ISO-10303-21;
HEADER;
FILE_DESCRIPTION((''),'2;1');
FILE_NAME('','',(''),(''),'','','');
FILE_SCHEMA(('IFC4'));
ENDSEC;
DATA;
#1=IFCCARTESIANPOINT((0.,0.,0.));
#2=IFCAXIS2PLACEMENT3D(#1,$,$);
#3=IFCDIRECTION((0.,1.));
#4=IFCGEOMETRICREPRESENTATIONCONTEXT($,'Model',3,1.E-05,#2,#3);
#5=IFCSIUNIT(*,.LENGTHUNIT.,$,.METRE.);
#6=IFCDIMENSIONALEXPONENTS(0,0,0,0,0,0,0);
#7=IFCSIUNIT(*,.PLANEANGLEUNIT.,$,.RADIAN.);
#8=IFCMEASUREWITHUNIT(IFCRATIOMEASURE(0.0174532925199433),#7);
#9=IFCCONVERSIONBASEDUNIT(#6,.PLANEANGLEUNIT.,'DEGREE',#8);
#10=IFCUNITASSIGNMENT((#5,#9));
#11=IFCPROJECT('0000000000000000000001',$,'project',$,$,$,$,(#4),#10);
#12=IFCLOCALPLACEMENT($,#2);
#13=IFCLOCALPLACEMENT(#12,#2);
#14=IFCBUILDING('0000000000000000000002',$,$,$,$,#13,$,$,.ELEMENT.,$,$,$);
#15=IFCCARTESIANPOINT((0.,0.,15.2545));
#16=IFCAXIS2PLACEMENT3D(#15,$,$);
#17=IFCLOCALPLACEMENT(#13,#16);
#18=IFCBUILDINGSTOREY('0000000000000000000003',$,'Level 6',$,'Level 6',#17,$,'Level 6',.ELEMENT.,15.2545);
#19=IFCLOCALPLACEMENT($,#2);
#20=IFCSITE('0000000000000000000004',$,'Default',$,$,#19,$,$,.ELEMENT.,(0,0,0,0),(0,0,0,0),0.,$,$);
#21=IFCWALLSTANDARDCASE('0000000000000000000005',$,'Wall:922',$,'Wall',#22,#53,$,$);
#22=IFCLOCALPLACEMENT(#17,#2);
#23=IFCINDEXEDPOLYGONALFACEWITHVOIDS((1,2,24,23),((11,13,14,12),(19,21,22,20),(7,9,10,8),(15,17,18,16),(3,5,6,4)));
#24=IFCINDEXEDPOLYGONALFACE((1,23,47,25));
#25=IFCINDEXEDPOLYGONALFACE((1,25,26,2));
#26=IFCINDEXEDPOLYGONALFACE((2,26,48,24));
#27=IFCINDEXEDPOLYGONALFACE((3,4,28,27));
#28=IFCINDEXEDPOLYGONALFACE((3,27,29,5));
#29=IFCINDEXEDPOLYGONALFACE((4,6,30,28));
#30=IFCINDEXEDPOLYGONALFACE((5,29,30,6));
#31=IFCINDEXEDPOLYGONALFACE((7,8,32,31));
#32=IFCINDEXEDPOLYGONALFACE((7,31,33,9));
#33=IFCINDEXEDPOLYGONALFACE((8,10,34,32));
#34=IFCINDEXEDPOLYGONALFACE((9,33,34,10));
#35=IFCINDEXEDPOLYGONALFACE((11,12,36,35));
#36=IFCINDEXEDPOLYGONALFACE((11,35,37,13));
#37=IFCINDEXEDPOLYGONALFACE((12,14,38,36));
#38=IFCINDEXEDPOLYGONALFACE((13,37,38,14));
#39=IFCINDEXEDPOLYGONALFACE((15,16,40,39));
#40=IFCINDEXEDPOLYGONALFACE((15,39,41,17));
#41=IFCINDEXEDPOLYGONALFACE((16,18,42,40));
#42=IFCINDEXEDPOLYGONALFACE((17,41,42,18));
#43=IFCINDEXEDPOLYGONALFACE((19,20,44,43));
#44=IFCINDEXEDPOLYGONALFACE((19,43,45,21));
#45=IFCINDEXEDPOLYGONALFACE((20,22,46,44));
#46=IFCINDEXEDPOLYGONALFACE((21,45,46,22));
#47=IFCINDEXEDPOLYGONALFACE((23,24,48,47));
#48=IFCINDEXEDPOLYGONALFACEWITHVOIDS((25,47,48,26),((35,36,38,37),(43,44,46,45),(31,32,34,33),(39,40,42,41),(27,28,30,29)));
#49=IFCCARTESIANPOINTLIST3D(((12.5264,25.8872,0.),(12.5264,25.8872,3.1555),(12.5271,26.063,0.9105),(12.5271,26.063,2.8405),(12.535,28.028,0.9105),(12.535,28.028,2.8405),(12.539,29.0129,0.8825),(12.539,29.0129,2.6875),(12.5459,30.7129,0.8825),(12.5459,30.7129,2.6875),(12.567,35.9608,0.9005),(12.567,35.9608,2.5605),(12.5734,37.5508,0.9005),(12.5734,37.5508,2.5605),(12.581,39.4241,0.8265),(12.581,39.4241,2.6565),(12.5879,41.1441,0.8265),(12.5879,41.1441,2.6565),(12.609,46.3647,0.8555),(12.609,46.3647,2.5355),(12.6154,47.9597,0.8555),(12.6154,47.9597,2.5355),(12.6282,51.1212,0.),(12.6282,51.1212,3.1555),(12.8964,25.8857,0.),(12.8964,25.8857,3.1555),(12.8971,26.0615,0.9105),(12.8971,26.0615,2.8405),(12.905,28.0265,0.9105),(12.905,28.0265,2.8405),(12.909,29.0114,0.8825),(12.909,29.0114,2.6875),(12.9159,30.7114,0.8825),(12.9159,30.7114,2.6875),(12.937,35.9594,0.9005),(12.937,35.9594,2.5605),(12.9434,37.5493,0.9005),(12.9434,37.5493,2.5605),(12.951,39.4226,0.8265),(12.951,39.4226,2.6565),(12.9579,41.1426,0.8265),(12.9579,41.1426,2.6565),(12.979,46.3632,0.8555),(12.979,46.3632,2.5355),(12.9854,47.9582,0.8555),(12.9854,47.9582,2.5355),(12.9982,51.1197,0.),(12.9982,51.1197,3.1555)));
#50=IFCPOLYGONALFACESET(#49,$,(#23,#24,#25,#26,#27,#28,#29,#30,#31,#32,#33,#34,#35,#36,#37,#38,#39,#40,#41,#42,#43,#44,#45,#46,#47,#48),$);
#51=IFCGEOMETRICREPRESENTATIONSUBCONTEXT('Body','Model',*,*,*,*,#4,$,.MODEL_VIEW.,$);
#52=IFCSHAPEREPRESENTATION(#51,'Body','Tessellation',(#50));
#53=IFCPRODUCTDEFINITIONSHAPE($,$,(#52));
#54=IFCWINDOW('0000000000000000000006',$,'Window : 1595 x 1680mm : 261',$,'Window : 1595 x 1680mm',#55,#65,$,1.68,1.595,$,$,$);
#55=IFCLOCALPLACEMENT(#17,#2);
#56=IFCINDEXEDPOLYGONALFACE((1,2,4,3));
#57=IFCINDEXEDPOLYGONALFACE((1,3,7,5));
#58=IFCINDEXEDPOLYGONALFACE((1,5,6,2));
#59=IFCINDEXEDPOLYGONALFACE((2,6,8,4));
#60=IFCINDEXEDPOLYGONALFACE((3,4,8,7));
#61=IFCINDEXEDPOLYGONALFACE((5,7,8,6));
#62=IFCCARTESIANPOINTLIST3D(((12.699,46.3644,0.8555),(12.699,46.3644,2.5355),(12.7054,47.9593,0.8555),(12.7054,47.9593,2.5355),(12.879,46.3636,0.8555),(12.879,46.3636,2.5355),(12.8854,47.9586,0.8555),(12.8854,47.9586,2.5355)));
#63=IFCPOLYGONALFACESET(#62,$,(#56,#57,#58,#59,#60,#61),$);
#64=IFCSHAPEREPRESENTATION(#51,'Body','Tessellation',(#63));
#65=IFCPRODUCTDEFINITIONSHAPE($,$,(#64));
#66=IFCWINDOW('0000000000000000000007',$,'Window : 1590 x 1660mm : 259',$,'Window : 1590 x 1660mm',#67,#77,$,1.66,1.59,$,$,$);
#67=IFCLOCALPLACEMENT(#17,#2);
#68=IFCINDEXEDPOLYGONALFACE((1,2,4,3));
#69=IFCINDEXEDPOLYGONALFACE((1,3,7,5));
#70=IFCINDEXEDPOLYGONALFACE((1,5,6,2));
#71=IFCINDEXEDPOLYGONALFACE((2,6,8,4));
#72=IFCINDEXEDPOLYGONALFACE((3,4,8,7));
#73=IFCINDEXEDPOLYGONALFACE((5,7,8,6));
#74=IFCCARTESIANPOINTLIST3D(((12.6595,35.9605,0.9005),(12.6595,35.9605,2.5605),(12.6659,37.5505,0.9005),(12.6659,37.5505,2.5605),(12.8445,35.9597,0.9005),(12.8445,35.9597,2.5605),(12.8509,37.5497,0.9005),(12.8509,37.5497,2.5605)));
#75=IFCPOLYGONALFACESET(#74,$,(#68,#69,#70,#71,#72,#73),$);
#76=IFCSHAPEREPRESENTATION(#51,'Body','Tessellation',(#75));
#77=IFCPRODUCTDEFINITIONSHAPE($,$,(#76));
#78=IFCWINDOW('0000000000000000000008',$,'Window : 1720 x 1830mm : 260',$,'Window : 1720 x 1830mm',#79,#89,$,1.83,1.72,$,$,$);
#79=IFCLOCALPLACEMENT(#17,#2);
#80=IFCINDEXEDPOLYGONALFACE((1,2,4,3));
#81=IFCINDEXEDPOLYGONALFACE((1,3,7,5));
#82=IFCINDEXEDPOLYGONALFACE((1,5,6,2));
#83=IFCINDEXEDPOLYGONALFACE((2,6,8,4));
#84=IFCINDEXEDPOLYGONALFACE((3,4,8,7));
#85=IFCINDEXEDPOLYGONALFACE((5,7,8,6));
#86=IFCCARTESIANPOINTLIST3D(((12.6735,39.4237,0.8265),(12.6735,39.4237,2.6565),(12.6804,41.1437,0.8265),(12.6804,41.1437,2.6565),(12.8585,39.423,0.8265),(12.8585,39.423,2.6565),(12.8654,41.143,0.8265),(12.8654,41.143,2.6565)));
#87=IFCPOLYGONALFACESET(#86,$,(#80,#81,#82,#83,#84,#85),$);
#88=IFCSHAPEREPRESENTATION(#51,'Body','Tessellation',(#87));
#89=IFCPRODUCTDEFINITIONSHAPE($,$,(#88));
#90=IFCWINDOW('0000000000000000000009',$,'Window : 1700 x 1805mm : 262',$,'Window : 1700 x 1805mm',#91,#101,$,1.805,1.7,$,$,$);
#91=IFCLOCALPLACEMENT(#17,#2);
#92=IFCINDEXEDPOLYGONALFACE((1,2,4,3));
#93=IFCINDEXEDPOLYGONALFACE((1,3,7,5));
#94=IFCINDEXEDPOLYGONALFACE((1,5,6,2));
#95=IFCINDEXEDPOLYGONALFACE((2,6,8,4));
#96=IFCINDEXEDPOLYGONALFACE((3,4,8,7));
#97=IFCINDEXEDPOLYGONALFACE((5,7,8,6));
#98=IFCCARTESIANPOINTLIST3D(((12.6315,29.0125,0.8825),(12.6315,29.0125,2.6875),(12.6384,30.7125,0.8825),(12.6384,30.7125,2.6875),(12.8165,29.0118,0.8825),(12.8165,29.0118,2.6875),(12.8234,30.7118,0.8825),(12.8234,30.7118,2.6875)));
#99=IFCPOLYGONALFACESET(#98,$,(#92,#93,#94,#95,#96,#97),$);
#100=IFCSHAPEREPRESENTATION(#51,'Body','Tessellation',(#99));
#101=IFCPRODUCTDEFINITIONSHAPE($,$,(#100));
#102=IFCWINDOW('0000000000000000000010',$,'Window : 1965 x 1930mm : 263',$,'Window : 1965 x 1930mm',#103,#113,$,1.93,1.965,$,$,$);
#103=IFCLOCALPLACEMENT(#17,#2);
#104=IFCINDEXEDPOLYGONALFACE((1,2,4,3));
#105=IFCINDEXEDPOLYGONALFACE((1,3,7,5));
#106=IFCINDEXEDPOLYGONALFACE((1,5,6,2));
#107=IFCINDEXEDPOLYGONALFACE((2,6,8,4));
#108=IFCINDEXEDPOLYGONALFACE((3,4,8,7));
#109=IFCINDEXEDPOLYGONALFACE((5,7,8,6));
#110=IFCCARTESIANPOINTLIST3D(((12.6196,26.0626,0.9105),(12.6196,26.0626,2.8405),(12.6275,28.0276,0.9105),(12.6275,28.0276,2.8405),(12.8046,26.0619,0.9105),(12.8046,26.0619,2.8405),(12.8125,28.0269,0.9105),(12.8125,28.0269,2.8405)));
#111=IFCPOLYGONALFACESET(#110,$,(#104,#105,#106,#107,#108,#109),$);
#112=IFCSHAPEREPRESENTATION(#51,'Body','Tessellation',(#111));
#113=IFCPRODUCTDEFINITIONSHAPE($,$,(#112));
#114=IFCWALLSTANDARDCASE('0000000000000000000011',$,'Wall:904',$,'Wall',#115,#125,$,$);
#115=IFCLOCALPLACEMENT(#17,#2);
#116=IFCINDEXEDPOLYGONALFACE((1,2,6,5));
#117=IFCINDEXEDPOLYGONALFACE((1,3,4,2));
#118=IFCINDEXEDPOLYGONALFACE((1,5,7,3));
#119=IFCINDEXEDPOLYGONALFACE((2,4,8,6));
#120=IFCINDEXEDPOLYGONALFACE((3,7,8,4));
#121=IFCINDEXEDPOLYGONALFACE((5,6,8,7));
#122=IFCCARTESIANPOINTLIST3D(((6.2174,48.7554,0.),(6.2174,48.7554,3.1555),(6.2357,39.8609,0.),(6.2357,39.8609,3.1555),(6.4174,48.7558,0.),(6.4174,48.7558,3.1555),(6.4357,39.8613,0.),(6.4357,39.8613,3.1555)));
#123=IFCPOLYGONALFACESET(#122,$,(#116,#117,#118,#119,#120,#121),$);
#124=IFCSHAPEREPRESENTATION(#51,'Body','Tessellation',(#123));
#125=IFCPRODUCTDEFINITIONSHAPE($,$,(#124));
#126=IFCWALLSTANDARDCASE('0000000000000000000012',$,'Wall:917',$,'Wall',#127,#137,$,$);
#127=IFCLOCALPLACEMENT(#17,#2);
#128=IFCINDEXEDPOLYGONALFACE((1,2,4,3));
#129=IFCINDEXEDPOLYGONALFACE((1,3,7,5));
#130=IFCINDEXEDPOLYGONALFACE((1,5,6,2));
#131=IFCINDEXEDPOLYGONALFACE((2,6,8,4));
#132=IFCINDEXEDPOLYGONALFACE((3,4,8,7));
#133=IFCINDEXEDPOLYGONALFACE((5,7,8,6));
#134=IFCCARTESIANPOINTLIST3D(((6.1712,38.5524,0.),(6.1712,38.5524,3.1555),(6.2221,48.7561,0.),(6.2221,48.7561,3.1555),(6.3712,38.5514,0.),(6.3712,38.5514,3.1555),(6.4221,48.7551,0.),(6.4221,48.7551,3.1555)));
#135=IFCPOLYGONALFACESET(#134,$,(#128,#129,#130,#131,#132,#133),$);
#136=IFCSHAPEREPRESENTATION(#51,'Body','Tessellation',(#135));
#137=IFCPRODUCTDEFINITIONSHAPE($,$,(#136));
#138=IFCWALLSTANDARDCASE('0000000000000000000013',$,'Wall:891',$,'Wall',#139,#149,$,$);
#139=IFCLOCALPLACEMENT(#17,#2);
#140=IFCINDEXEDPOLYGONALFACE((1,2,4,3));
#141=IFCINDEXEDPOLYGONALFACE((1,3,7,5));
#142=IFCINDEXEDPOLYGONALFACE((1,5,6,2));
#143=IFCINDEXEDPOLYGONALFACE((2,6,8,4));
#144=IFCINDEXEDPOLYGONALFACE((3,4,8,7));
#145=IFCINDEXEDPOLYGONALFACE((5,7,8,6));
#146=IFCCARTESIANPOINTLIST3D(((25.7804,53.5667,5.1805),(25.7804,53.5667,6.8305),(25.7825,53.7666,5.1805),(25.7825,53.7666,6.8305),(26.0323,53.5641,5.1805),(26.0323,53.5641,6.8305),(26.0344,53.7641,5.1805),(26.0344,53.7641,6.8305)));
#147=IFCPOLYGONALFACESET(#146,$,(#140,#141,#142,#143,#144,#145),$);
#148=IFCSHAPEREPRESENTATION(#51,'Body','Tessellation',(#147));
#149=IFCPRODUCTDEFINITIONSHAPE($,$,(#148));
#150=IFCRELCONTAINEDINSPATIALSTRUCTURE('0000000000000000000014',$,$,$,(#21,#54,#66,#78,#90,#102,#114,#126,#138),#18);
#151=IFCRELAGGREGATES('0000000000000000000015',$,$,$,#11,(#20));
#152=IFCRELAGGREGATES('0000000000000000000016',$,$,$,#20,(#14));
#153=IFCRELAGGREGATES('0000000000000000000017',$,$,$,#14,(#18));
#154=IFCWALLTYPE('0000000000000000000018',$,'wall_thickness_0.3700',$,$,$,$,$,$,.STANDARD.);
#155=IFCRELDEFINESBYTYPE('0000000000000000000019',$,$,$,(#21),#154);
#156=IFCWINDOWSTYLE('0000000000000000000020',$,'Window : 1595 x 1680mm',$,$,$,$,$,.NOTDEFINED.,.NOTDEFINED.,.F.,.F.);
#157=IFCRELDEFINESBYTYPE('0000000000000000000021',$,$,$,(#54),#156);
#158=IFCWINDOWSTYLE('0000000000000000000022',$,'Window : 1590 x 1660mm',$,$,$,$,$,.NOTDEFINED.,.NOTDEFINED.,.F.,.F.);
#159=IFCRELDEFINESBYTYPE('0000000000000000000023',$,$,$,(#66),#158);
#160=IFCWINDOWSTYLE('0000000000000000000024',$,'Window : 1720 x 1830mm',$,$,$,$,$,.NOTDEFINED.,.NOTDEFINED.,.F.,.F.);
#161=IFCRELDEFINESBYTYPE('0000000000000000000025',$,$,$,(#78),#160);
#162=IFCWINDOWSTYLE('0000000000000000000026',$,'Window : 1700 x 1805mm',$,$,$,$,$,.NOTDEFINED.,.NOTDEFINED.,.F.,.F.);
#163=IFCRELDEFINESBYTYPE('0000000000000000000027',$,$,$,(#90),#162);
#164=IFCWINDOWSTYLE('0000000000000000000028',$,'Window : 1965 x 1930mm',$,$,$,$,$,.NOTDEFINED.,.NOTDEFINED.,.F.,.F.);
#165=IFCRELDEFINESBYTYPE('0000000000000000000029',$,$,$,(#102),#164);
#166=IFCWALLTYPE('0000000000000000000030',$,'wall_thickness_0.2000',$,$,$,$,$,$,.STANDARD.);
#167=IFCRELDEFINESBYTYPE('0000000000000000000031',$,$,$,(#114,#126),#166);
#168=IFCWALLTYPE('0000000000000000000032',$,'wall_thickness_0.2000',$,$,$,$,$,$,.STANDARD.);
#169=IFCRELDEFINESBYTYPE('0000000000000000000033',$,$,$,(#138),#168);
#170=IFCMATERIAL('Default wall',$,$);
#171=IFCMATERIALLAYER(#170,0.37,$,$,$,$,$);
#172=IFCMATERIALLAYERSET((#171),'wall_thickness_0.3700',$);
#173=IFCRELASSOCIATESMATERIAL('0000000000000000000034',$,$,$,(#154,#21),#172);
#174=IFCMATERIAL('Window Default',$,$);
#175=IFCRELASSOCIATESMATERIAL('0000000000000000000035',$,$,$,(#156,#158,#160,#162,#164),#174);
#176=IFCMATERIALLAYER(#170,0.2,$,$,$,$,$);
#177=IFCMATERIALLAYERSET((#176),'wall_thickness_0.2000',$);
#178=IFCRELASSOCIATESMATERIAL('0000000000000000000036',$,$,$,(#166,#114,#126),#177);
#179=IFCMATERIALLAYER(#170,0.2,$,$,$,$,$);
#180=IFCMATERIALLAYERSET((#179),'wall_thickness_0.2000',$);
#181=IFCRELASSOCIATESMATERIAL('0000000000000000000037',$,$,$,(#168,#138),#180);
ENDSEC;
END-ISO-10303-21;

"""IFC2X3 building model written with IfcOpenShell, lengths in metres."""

from ifc_helpers import new_model, entity, si_unit, converted_unit, direction, frame, frame_2d, origin, origin_2d_with_axis, place, context, subcontext, project, spatial, polyline, rectangle, outline, extrude, source, transform, mapped, material, layer, layer_set, layer_usage, type_object, type_shapes, element, fill, save


model = new_model("IFC2X3")

# Units and contexts
model_context = context("Model", 3, precision=1e-05, world=origin(), true_north=direction((0.0, 1.0)))
body_context = subcontext(model_context, "Body", "Model", "MODEL_VIEW")
ifc_project = project(units=[si_unit("LENGTHUNIT", "METRE"), converted_unit("PLANEANGLEUNIT", "DEGREE", entity("IfcRatioMeasure", 0.0174532925199433), si_unit("PLANEANGLEUNIT", "RADIAN"), dimensions=[0, 0, 0, 0, 0, 0, 0])], contexts=[model_context])

# Site, building, storey
site_placement = place(None, origin())
site = spatial("IfcSite", under=ifc_project, at=site_placement, Name="Default", CompositionType="ELEMENT", RefLatitude=(0, 0, 0, 0), RefLongitude=(0, 0, 0, 0), RefElevation=0.0)
placement_1 = place(None, origin())
building_placement = place(placement_1, origin())
building = spatial("IfcBuilding", under=site, at=building_placement, CompositionType="ELEMENT")
storey_placement = place(building_placement, frame((0.0, 0.0, 15.2545)))
storey = spatial("IfcBuildingStorey", under=building, at=storey_placement, Name="Level 6", ObjectType="Level 6", LongName="Level 6", CompositionType="ELEMENT", Elevation=15.2545)

# Shared definitions
ifc_material_1 = material(Name="Default wall")
ifc_layer_1 = layer(ifc_material_1, 0.37)
ifc_layer_set_1 = layer_set([ifc_layer_1], Name="wall_thickness_0.3700")
ifc_layer_usage_1 = layer_usage(ifc_layer_set_1, "AXIS2", "POSITIVE", -0.185)
wall_type_1 = type_object("IfcWallType", Name="wall_thickness_0.3700", PredefinedType="STANDARD", material=ifc_layer_set_1)
ifc_material_2 = material(Name="Window Default")

# Wall, openings, windows
wall_1_placement = place(storey_placement, frame((12.8132, 51.1205, 0.0), z_axis=(0.0, 0.0, 1.0), x_axis=(-0.004033, -0.999992, 0.0)))
wall_1 = element("IfcWallStandardCase", 1, at=wall_1_placement, inside=storey, type_object=wall_type_1, material=ifc_layer_usage_1, Name="Wall:922", ObjectType="Wall", context=body_context, shape_type="SweptSolid", body=[
    extrude(outline(polyline([(25.2342, -0.185), (25.2342, 0.185), (0.0, 0.185), (0.0, -0.185), (25.2342, -0.185)])), origin(), (0.0, 0.0, 1.0), 3.1555),
])
opening_1_placement = place(wall_1_placement, frame((13.5705, -0.185, 0.9005)))
opening_1 = element("IfcOpeningElement", 2, at=opening_1_placement, cuts=wall_1, ObjectType="Opening", context=body_context, shape_type="SweptSolid", body=[
    extrude(rectangle(XDim=1.59, YDim=1.66, at=frame_2d((0.83, 0.795), x_axis=(0.0, 1.0))), frame((0.0, 0.0, 0.0), z_axis=(0.0, 1.0, 0.0), x_axis=(0.0, 0.0, 1.0)), (0.0, 0.0, 1.0), 0.37),
])
opening_2_placement = place(wall_1_placement, frame((9.9772, -0.185, 0.8265)))
opening_2 = element("IfcOpeningElement", 3, at=opening_2_placement, cuts=wall_1, ObjectType="Opening", context=body_context, shape_type="SweptSolid", body=[
    extrude(rectangle(XDim=1.72, YDim=1.83, at=frame_2d((0.915, 0.86), x_axis=(0.0, 1.0))), frame((0.0, 0.0, 0.0), z_axis=(0.0, 1.0, 0.0), x_axis=(0.0, 0.0, 1.0)), (0.0, 0.0, 1.0), 0.37),
])
opening_3_placement = place(wall_1_placement, frame((3.1615, -0.185, 0.8555)))
opening_3 = element("IfcOpeningElement", 4, at=opening_3_placement, cuts=wall_1, ObjectType="Opening", context=body_context, shape_type="SweptSolid", body=[
    extrude(rectangle(XDim=1.595, YDim=1.68, at=frame_2d((0.84, 0.7975), x_axis=(0.0, 1.0))), frame((0.0, 0.0, 0.0), z_axis=(0.0, 1.0, 0.0), x_axis=(0.0, 0.0, 1.0)), (0.0, 0.0, 1.0), 0.37),
])
opening_4_placement = place(wall_1_placement, frame((20.4085, -0.185, 0.8825)))
opening_4 = element("IfcOpeningElement", 5, at=opening_4_placement, cuts=wall_1, ObjectType="Opening", context=body_context, shape_type="SweptSolid", body=[
    extrude(rectangle(XDim=1.7, YDim=1.805, at=frame_2d((0.9025, 0.85), x_axis=(0.0, 1.0))), frame((0.0, 0.0, 0.0), z_axis=(0.0, 1.0, 0.0), x_axis=(0.0, 0.0, 1.0)), (0.0, 0.0, 1.0), 0.37),
])
opening_5_placement = place(wall_1_placement, frame((23.0934, -0.185, 0.9105)))
opening_5 = element("IfcOpeningElement", 6, at=opening_5_placement, cuts=wall_1, ObjectType="Opening", context=body_context, shape_type="SweptSolid", body=[
    extrude(rectangle(XDim=1.965, YDim=1.93, at=frame_2d((0.965, 0.9825), x_axis=(0.0, 1.0))), frame((0.0, 0.0, 0.0), z_axis=(0.0, 1.0, 0.0), x_axis=(0.0, 0.0, 1.0)), (0.0, 0.0, 1.0), 0.37),
])
window_style_1 = type_object("IfcWindowStyle", Name="Window : 1595 x 1680mm", ConstructionType="NOTDEFINED", OperationType="NOTDEFINED", ParameterTakesPrecedence=False, Sizeable=False, material=ifc_material_2)
shared_shape_1 = source(origin(), body_context, "Body", "SweptSolid", [
    extrude(rectangle(XDim=0.18, YDim=1.595, at=origin_2d_with_axis()), frame((0.7975, 0.18, 0.0), z_axis=(0.0, 0.0, 1.0), x_axis=(0.0, 1.0, 0.0)), (0.0, 0.0, 1.0), 1.68),
])
type_shapes(window_style_1, [shared_shape_1])
window_1_placement = place(opening_3_placement, origin())
window_1 = element("IfcWindow", 7, at=window_1_placement, inside=storey, type_object=window_style_1, Name="Window : 1595 x 1680mm : 261", ObjectType="Window : 1595 x 1680mm", OverallHeight=1.68, OverallWidth=1.595, context=body_context, shape_type="MappedRepresentation", body=[
    mapped(shared_shape_1, transform((0.0, 0.0, 0.0), scale=1.0)),
])
fill(opening_3, window_1)
window_style_2 = type_object("IfcWindowStyle", Name="Window : 1590 x 1660mm", ConstructionType="NOTDEFINED", OperationType="NOTDEFINED", ParameterTakesPrecedence=False, Sizeable=False, material=ifc_material_2)
shared_shape_2 = source(origin(), body_context, "Body", "SweptSolid", [
    extrude(rectangle(XDim=0.185, YDim=1.59, at=origin_2d_with_axis()), frame((0.795, 0.185, 0.0), z_axis=(0.0, 0.0, 1.0), x_axis=(0.0, 1.0, 0.0)), (0.0, 0.0, 1.0), 1.66),
])
type_shapes(window_style_2, [shared_shape_2])
window_2_placement = place(opening_1_placement, origin())
window_2 = element("IfcWindow", 8, at=window_2_placement, inside=storey, type_object=window_style_2, Name="Window : 1590 x 1660mm : 259", ObjectType="Window : 1590 x 1660mm", OverallHeight=1.66, OverallWidth=1.59, context=body_context, shape_type="MappedRepresentation", body=[
    mapped(shared_shape_2, transform((0.0, 0.0, 0.0), scale=1.0)),
])
fill(opening_1, window_2)
window_style_3 = type_object("IfcWindowStyle", Name="Window : 1720 x 1830mm", ConstructionType="NOTDEFINED", OperationType="NOTDEFINED", ParameterTakesPrecedence=False, Sizeable=False, material=ifc_material_2)
shared_shape_3 = source(origin(), body_context, "Body", "SweptSolid", [
    extrude(rectangle(XDim=0.185, YDim=1.72, at=origin_2d_with_axis()), frame((0.86, 0.185, 0.0), z_axis=(0.0, 0.0, 1.0), x_axis=(0.0, 1.0, 0.0)), (0.0, 0.0, 1.0), 1.83),
])
type_shapes(window_style_3, [shared_shape_3])
window_3_placement = place(opening_2_placement, origin())
window_3 = element("IfcWindow", 9, at=window_3_placement, inside=storey, type_object=window_style_3, Name="Window : 1720 x 1830mm : 260", ObjectType="Window : 1720 x 1830mm", OverallHeight=1.83, OverallWidth=1.72, context=body_context, shape_type="MappedRepresentation", body=[
    mapped(shared_shape_3, transform((0.0, 0.0, 0.0), scale=1.0)),
])
fill(opening_2, window_3)
window_style_4 = type_object("IfcWindowStyle", Name="Window : 1700 x 1805mm", ConstructionType="NOTDEFINED", OperationType="NOTDEFINED", ParameterTakesPrecedence=False, Sizeable=False, material=ifc_material_2)
shared_shape_4 = source(origin(), body_context, "Body", "SweptSolid", [
    extrude(rectangle(XDim=0.185, YDim=1.7, at=origin_2d_with_axis()), frame((0.85, 0.185, 0.0), z_axis=(0.0, 0.0, 1.0), x_axis=(0.0, 1.0, 0.0)), (0.0, 0.0, 1.0), 1.805),
])
type_shapes(window_style_4, [shared_shape_4])
window_4_placement = place(opening_4_placement, origin())
window_4 = element("IfcWindow", 10, at=window_4_placement, inside=storey, type_object=window_style_4, Name="Window : 1700 x 1805mm : 262", ObjectType="Window : 1700 x 1805mm", OverallHeight=1.805, OverallWidth=1.7, context=body_context, shape_type="MappedRepresentation", body=[
    mapped(shared_shape_4, transform((0.0, 0.0, 0.0), scale=1.0)),
])
fill(opening_4, window_4)
window_style_5 = type_object("IfcWindowStyle", Name="Window : 1965 x 1930mm", ConstructionType="NOTDEFINED", OperationType="NOTDEFINED", ParameterTakesPrecedence=False, Sizeable=False, material=ifc_material_2)
shared_shape_5 = source(origin(), body_context, "Body", "SweptSolid", [
    extrude(rectangle(XDim=0.185, YDim=1.965, at=origin_2d_with_axis()), frame((0.9825, 0.185, 0.0), z_axis=(0.0, 0.0, 1.0), x_axis=(0.0, 1.0, 0.0)), (0.0, 0.0, 1.0), 1.93),
])
type_shapes(window_style_5, [shared_shape_5])
window_5_placement = place(opening_5_placement, origin())
window_5 = element("IfcWindow", 11, at=window_5_placement, inside=storey, type_object=window_style_5, Name="Window : 1965 x 1930mm : 263", ObjectType="Window : 1965 x 1930mm", OverallHeight=1.93, OverallWidth=1.965, context=body_context, shape_type="MappedRepresentation", body=[
    mapped(shared_shape_5, transform((0.0, 0.0, 0.0), scale=1.0)),
])
fill(opening_5, window_5)

# Walls
ifc_layer_2 = layer(ifc_material_1, 0.2)
ifc_layer_set_2 = layer_set([ifc_layer_2], Name="wall_thickness_0.2000")
ifc_layer_usage_2 = layer_usage(ifc_layer_set_2, "AXIS2", "POSITIVE", -0.1)
wall_type_2 = type_object("IfcWallType", Name="wall_thickness_0.2000", PredefinedType="STANDARD", material=ifc_layer_set_2)
wall_2_placement = place(storey_placement, frame((6.3174, 48.7556, 0.0), z_axis=(0.0, 0.0, 1.0), x_axis=(0.002062, -0.999998, 0.0)))
element("IfcWallStandardCase", 12, at=wall_2_placement, inside=storey, type_object=wall_type_2, material=ifc_layer_usage_2, Name="Wall:904", ObjectType="Wall", context=body_context, shape_type="SweptSolid", body=[
    extrude(outline(polyline([(8.8945, -0.1), (8.8945, 0.1), (0.0, 0.1), (0.0, -0.1), (8.8945, -0.1)])), origin(), (0.0, 0.0, 1.0), 3.1555),
])
wall_3_placement = place(storey_placement, frame((6.3221, 48.7556, 0.0), z_axis=(0.0, 0.0, 1.0), x_axis=(-0.004992, -0.999988, 0.0)))
element("IfcWallStandardCase", 13, at=wall_3_placement, inside=storey, type_object=wall_type_2, material=ifc_layer_usage_2, Name="Wall:917", ObjectType="Wall", context=body_context, shape_type="SweptSolid", body=[
    extrude(outline(polyline([(10.2037, -0.1), (10.2037, 0.1), (0.0, 0.1), (0.0, -0.1), (10.2037, -0.1)])), origin(), (0.0, 0.0, 1.0), 3.1555),
])
ifc_layer_3 = layer(ifc_material_1, 0.2)
ifc_layer_set_3 = layer_set([ifc_layer_3], Name="wall_thickness_0.2000")
ifc_layer_usage_3 = layer_usage(ifc_layer_set_3, "AXIS2", "POSITIVE", -0.1)
wall_type_3 = type_object("IfcWallType", Name="wall_thickness_0.2000", PredefinedType="STANDARD", material=ifc_layer_set_3)
placement_2 = place(building_placement, frame((0.0, 0.0, 20.435)))
wall_4_placement = place(placement_2, frame((26.0333, 53.6641, 0.0), z_axis=(0.0, 0.0, 1.0), x_axis=(-0.999948, 0.010193, 0.0)))
element("IfcWallStandardCase", 14, at=wall_4_placement, inside=storey, type_object=wall_type_3, material=ifc_layer_usage_3, Name="Wall:891", ObjectType="Wall", context=body_context, shape_type="SweptSolid", body=[
    extrude(outline(polyline([(0.2519, -0.1), (0.2519, 0.1), (0.0, 0.1), (0.0, -0.1), (0.2519, -0.1)])), origin(), (0.0, 0.0, 1.0), 1.65),
])

save(model, "model.ifc")
